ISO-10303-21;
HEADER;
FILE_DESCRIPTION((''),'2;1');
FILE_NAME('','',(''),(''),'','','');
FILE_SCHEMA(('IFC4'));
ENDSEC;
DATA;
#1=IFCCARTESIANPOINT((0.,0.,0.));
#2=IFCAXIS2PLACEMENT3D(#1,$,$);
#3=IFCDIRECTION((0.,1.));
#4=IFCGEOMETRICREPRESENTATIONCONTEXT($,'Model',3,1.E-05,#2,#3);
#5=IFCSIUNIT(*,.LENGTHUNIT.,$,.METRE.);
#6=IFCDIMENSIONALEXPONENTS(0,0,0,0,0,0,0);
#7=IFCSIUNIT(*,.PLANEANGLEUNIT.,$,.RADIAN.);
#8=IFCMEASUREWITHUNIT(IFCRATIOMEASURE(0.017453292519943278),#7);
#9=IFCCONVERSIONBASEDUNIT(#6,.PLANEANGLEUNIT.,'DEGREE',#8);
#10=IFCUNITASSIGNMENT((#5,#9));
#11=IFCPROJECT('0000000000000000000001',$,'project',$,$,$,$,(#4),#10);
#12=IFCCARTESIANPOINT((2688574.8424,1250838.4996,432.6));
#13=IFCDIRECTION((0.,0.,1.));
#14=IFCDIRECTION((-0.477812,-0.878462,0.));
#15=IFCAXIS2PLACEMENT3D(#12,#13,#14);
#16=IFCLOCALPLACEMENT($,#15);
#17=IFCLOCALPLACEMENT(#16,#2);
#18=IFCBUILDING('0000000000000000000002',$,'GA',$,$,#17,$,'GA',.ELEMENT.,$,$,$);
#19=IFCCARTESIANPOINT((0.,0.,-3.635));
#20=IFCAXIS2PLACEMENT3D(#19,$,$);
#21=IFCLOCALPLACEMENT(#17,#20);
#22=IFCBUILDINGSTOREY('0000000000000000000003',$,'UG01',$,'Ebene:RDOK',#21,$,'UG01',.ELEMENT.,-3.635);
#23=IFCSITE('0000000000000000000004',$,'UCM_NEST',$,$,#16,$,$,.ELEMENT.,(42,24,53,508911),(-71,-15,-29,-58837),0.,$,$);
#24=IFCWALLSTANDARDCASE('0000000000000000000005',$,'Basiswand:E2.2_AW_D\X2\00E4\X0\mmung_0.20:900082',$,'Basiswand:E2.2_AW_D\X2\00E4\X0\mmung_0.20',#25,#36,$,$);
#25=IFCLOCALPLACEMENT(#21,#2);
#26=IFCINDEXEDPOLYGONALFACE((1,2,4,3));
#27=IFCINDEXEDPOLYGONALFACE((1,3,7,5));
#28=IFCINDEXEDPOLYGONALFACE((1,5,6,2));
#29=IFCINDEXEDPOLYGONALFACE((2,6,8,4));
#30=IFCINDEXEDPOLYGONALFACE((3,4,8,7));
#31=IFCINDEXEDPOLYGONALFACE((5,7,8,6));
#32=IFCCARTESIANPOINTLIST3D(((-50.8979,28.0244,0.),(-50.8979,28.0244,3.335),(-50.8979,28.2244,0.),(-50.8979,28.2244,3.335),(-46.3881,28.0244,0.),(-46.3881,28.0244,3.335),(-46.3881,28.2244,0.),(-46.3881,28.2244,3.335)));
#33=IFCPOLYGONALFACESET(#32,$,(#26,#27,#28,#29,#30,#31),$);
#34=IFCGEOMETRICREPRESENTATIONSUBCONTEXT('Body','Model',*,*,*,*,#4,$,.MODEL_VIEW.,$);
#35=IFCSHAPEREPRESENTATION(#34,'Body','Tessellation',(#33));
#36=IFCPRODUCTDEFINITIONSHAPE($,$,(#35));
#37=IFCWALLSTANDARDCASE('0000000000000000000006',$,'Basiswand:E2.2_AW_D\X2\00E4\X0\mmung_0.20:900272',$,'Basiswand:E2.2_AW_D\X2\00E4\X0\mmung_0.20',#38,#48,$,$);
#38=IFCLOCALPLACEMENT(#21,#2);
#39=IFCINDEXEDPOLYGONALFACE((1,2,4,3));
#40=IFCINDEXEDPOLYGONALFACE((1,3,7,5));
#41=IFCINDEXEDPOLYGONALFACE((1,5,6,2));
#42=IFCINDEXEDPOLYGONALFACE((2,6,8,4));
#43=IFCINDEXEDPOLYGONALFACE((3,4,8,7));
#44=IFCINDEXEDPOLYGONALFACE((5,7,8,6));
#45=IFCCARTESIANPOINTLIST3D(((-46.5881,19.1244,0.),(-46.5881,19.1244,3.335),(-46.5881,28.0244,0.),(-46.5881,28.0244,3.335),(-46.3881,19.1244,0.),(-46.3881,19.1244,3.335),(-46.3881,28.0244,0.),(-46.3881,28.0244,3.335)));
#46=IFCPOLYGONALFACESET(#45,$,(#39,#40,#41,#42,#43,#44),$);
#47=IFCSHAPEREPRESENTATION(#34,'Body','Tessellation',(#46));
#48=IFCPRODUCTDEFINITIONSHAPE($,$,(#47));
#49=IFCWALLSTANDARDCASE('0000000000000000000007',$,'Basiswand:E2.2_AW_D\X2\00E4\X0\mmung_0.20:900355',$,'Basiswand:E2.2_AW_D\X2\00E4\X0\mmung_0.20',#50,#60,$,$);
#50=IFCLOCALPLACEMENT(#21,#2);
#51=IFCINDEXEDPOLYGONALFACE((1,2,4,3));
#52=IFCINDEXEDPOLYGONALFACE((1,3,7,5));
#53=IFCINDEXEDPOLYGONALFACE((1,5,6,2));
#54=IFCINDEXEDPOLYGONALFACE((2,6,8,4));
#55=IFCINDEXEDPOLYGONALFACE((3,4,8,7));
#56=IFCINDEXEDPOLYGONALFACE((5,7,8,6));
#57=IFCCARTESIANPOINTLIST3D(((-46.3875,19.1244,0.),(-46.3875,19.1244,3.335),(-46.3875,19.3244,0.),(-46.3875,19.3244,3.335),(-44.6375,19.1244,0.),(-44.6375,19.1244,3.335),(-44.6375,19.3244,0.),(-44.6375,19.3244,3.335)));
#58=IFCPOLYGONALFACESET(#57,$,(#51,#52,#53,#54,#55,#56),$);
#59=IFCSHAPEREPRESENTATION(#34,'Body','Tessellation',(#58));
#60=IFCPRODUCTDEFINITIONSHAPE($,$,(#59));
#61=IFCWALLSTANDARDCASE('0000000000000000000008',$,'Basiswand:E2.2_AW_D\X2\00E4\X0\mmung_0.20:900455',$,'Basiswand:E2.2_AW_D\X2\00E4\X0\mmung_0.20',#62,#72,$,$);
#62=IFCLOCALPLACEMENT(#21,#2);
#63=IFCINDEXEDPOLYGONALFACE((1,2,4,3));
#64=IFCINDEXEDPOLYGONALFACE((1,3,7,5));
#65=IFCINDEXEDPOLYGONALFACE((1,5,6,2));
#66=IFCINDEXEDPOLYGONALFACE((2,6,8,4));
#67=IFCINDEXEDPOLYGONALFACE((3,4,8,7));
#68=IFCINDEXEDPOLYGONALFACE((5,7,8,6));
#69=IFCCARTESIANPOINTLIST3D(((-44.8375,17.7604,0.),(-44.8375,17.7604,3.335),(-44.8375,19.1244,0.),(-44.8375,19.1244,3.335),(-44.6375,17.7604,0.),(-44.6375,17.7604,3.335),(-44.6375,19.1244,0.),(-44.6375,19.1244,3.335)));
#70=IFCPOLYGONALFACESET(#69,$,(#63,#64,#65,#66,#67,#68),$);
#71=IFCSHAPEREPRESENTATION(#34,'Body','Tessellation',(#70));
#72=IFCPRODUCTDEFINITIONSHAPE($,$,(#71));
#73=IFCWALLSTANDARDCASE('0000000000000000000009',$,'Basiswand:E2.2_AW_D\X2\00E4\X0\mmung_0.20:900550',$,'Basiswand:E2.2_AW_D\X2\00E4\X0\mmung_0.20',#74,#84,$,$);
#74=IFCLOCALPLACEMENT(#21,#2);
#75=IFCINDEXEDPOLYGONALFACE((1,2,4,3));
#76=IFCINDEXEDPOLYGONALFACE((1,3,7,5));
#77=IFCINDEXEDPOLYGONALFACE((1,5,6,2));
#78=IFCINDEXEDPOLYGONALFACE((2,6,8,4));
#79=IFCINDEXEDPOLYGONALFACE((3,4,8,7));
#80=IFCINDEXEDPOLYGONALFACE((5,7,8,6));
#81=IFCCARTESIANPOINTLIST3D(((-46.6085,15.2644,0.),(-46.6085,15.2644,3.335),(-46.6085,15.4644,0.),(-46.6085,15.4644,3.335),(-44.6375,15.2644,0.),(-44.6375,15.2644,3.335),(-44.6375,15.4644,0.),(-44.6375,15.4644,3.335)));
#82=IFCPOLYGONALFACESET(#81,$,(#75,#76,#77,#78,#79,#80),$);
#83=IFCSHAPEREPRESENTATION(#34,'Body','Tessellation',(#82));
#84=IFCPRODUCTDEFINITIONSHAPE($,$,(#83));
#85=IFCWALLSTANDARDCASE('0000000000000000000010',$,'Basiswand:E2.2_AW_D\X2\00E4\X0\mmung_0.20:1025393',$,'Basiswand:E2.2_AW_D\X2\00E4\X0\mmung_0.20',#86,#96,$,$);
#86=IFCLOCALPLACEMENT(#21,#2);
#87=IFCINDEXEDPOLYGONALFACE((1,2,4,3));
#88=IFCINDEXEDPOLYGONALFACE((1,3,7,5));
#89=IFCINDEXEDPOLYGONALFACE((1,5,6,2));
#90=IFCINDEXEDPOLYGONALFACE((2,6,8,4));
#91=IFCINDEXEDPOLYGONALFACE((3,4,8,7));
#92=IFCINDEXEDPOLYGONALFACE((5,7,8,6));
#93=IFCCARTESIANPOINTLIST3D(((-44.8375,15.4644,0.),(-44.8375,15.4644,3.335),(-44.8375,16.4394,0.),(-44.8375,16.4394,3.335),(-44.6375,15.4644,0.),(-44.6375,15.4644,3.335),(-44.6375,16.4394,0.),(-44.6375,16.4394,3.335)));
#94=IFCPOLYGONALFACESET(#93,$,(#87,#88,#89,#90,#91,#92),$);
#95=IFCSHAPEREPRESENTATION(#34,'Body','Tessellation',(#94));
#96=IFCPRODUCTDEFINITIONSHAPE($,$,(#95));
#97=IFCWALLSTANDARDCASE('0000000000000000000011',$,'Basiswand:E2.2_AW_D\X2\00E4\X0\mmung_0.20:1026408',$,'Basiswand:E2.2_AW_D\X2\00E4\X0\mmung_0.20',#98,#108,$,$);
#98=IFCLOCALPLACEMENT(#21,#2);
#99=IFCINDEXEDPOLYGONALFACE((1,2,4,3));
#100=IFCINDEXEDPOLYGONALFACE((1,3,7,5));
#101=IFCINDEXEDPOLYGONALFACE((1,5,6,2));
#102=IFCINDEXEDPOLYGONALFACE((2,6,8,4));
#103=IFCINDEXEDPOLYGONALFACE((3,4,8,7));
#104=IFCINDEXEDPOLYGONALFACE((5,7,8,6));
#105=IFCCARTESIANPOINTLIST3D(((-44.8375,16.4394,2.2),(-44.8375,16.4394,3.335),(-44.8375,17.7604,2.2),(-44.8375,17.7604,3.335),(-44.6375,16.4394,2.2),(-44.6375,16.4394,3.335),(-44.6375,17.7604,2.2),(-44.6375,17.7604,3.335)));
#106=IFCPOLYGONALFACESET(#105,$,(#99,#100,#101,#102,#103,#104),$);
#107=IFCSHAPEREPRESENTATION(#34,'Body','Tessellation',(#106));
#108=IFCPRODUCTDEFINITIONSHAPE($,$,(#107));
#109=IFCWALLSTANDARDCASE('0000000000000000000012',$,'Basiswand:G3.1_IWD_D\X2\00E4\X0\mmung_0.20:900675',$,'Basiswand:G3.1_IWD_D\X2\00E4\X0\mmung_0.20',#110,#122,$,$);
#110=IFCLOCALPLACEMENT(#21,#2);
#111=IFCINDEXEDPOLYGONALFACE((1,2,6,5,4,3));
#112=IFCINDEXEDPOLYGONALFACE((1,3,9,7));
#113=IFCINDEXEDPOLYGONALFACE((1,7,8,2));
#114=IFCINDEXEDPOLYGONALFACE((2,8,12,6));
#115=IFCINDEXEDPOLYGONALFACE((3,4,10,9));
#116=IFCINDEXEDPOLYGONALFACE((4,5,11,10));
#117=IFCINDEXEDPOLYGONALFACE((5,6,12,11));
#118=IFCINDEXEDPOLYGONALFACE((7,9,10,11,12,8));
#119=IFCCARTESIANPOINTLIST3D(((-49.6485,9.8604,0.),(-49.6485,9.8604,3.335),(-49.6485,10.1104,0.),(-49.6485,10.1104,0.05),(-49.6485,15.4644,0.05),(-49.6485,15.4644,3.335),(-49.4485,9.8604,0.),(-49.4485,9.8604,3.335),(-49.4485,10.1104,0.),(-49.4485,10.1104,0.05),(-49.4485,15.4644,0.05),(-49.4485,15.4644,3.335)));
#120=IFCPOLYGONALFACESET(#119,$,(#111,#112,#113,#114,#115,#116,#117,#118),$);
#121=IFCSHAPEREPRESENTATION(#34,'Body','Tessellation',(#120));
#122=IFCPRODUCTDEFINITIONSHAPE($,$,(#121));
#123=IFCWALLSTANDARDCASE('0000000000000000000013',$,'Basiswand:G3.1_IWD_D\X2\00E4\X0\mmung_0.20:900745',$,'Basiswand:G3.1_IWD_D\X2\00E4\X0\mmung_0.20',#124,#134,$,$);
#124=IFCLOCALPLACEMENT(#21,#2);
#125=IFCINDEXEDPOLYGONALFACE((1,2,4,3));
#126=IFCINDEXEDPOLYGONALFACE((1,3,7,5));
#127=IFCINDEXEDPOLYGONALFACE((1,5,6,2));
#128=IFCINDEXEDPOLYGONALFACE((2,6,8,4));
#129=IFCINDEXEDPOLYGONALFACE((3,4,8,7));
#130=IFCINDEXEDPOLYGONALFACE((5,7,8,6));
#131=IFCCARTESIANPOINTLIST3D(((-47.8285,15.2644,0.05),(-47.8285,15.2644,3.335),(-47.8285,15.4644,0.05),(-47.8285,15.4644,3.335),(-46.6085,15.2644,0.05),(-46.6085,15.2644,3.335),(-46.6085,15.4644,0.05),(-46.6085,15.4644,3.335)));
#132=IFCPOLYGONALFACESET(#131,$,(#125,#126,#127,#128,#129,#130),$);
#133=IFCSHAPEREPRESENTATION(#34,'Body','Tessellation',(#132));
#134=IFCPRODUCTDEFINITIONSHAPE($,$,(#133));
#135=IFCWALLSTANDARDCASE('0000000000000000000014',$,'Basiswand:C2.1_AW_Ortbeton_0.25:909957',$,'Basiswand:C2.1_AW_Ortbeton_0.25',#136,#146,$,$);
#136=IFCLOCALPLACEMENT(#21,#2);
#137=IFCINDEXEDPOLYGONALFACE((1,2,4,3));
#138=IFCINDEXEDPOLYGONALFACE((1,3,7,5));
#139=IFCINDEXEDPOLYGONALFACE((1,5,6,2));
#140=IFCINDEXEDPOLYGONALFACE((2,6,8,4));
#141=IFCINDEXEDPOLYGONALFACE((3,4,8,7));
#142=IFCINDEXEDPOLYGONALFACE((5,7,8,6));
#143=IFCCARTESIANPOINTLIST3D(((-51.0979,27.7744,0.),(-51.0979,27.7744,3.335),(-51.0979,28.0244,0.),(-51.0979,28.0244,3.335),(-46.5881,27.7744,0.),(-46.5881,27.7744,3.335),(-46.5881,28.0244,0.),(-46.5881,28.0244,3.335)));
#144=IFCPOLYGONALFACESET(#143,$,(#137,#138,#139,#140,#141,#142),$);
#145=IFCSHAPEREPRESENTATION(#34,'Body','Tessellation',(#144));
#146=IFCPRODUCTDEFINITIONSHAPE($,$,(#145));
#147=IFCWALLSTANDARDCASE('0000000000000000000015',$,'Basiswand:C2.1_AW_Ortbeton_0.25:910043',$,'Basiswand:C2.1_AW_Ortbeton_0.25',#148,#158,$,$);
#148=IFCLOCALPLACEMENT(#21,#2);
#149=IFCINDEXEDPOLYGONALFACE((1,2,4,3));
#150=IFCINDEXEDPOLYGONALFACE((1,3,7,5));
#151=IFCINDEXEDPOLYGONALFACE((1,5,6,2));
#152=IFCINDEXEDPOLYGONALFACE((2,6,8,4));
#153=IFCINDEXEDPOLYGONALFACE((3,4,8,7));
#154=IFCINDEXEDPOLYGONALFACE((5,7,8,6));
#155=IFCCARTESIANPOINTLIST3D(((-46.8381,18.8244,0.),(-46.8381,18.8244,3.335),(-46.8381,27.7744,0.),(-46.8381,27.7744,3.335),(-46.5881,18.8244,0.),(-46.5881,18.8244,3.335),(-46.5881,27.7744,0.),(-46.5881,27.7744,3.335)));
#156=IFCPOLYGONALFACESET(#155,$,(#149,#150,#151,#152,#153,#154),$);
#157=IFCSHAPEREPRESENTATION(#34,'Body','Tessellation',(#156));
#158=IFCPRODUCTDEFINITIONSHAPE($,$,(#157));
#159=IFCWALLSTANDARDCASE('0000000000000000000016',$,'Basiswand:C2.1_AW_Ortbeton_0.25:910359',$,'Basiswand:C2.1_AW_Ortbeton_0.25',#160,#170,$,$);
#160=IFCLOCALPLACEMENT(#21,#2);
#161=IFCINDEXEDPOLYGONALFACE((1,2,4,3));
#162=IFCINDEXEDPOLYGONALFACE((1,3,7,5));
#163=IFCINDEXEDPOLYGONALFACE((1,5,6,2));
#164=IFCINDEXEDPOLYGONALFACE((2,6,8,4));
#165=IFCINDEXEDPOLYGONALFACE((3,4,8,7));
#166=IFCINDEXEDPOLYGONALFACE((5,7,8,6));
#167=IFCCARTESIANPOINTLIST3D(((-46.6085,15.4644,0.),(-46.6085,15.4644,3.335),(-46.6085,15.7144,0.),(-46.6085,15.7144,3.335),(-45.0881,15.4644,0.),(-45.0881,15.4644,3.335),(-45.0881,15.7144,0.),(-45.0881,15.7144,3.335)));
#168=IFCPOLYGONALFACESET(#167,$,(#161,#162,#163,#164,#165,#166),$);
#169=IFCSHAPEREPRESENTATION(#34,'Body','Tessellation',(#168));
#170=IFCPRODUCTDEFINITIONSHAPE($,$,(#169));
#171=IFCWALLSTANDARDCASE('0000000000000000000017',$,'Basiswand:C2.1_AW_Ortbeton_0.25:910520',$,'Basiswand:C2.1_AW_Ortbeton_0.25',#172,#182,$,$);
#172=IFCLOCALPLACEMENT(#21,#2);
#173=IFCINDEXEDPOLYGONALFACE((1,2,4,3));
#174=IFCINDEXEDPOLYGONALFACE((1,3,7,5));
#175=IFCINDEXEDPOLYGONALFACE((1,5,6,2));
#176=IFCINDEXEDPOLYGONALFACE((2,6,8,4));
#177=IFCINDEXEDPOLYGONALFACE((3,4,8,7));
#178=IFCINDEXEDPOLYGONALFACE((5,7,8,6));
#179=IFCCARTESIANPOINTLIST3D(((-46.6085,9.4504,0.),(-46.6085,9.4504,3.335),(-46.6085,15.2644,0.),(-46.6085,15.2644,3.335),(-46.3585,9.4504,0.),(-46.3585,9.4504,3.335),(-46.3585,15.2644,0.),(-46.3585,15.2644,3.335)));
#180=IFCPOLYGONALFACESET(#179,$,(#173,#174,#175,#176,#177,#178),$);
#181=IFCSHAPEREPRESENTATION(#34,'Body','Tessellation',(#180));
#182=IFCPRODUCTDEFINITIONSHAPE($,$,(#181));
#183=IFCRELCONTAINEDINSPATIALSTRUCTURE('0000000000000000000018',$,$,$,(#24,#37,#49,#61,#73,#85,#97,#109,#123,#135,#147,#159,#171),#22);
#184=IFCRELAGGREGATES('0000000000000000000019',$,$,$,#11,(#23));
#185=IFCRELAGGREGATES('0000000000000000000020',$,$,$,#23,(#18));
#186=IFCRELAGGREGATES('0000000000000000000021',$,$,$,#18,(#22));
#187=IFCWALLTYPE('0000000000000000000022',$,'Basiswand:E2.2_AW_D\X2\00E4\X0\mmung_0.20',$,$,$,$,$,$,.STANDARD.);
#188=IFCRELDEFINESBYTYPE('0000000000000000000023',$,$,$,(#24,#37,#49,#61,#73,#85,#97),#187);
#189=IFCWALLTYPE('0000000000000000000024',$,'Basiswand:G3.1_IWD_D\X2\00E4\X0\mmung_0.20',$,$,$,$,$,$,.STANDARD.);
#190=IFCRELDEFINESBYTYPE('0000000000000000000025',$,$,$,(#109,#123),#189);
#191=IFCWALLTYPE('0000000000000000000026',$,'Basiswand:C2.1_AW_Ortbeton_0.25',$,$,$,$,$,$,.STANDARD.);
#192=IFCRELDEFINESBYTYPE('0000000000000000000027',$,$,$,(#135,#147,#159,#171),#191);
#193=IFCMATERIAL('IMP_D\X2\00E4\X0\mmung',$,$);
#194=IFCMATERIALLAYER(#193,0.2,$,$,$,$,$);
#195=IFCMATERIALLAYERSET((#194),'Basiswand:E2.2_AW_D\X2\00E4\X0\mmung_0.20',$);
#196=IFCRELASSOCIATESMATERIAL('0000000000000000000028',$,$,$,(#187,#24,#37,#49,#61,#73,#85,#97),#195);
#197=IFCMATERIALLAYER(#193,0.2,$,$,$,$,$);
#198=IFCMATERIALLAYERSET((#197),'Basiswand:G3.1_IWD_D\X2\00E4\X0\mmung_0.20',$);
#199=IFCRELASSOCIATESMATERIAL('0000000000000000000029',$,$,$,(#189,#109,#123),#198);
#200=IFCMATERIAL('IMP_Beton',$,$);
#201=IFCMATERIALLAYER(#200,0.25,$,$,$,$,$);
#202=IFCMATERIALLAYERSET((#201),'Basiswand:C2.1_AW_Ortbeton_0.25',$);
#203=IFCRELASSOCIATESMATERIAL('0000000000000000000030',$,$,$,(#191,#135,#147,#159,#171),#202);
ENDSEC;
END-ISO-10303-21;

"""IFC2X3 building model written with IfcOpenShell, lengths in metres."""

from ifc_helpers import new_model, entity, si_unit, converted_unit, direction, frame, frame_2d, origin, place, context, subcontext, project, spatial, polyline, rectangle, extrude, clip, bounded_halfspace, material, layer, layer_set, layer_usage, type_object, element, save


model = new_model("IFC2X3")

# Units and contexts
model_context = context("Model", 3, precision=1e-05, world=origin(), true_north=direction((0.0, 1.0)))
body_context = subcontext(model_context, "Body", "Model", "MODEL_VIEW")
ifc_project = project(units=[si_unit("LENGTHUNIT", "METRE"), converted_unit("PLANEANGLEUNIT", "DEGREE", entity("IfcRatioMeasure", 0.017453292519943278), si_unit("PLANEANGLEUNIT", "RADIAN"), dimensions=[0, 0, 0, 0, 0, 0, 0])], contexts=[model_context])

# Site, building, storey
site_placement = place(None, frame((2688574.8424, 1250838.4996, 432.6), z_axis=(0.0, 0.0, 1.0), x_axis=(-0.477812, -0.878462, 0.0)))
site = spatial("IfcSite", under=ifc_project, at=site_placement, Name="UCM_NEST", CompositionType="ELEMENT", RefLatitude=(42, 24, 53, 508911), RefLongitude=(-71, -15, -29, -58837), RefElevation=0.0)
building_placement = place(site_placement, origin())
building = spatial("IfcBuilding", under=site, at=building_placement, Name="GA", LongName="GA", CompositionType="ELEMENT")
storey_placement = place(building_placement, frame((0.0, 0.0, -3.635)))
storey = spatial("IfcBuildingStorey", under=building, at=storey_placement, Name="UG01", ObjectType="Ebene:RDOK", LongName="UG01", CompositionType="ELEMENT", Elevation=-3.635)

# Shared definitions
ifc_material_1 = material(Name="IMP_Beton")

# Walls
ifc_material_2 = material(Name="IMP_Dämmung")
ifc_layer_1 = layer(ifc_material_2, 0.2)
ifc_layer_set_1 = layer_set([ifc_layer_1], Name="Basiswand:E2.2_AW_Dämmung_0.20")
ifc_layer_usage_1 = layer_usage(ifc_layer_set_1, "AXIS2", "NEGATIVE", 0.1)
wall_type_1 = type_object("IfcWallType", Name="Basiswand:E2.2_AW_Dämmung_0.20", PredefinedType="STANDARD", material=ifc_layer_set_1)
wall_1_placement = place(storey_placement, frame((-50.8979, 28.1244, 0.0)))
element("IfcWallStandardCase", 1, at=wall_1_placement, inside=storey, type_object=wall_type_1, material=ifc_layer_usage_1, Name="Basiswand:E2.2_AW_Dämmung_0.20:900082", ObjectType="Basiswand:E2.2_AW_Dämmung_0.20", context=body_context, shape_type="SweptSolid", body=[
    extrude(rectangle(XDim=4.5099, YDim=0.2, at=frame_2d((2.2549, 0.0), x_axis=(-1.0, 0.0))), origin(), (0.0, 0.0, 1.0), 3.335),
])
wall_2_placement = place(storey_placement, frame((-46.4881, 28.0244, 0.0), z_axis=(0.0, 0.0, 1.0), x_axis=(0.0, -1.0, 0.0)))
element("IfcWallStandardCase", 2, at=wall_2_placement, inside=storey, type_object=wall_type_1, material=ifc_layer_usage_1, Name="Basiswand:E2.2_AW_Dämmung_0.20:900272", ObjectType="Basiswand:E2.2_AW_Dämmung_0.20", context=body_context, shape_type="SweptSolid", body=[
    extrude(rectangle(XDim=8.9, YDim=0.2, at=frame_2d((4.45, 0.0), x_axis=(-1.0, 0.0))), origin(), (0.0, 0.0, 1.0), 3.335),
])
wall_3_placement = place(storey_placement, frame((-46.3875, 19.2244, 0.0)))
element("IfcWallStandardCase", 3, at=wall_3_placement, inside=storey, type_object=wall_type_1, material=ifc_layer_usage_1, Name="Basiswand:E2.2_AW_Dämmung_0.20:900355", ObjectType="Basiswand:E2.2_AW_Dämmung_0.20", context=body_context, shape_type="SweptSolid", body=[
    extrude(rectangle(XDim=1.75, YDim=0.2, at=frame_2d((0.875, 0.0), x_axis=(-1.0, 0.0))), origin(), (0.0, 0.0, 1.0), 3.335),
])
wall_4_placement = place(storey_placement, frame((-44.7375, 19.1244, 0.0), z_axis=(0.0, 0.0, 1.0), x_axis=(0.0, -1.0, 0.0)))
element("IfcWallStandardCase", 4, at=wall_4_placement, inside=storey, type_object=wall_type_1, material=ifc_layer_usage_1, Name="Basiswand:E2.2_AW_Dämmung_0.20:900455", ObjectType="Basiswand:E2.2_AW_Dämmung_0.20", context=body_context, shape_type="SweptSolid", body=[
    extrude(rectangle(XDim=1.364, YDim=0.2, at=frame_2d((0.682, 0.0), x_axis=(-1.0, 0.0))), origin(), (0.0, 0.0, 1.0), 3.335),
])
wall_5_placement = place(storey_placement, frame((-44.6375, 15.3644, 0.0), z_axis=(0.0, 0.0, 1.0), x_axis=(-1.0, 0.0, 0.0)))
element("IfcWallStandardCase", 5, at=wall_5_placement, inside=storey, type_object=wall_type_1, material=ifc_layer_usage_1, Name="Basiswand:E2.2_AW_Dämmung_0.20:900550", ObjectType="Basiswand:E2.2_AW_Dämmung_0.20", context=body_context, shape_type="SweptSolid", body=[
    extrude(rectangle(XDim=1.971, YDim=0.2, at=frame_2d((0.9855, 0.0), x_axis=(-1.0, 0.0))), origin(), (0.0, 0.0, 1.0), 3.335),
])
wall_6_placement = place(storey_placement, frame((-44.7375, 16.4394, 0.0), z_axis=(0.0, 0.0, 1.0), x_axis=(0.0, -1.0, 0.0)))
element("IfcWallStandardCase", 6, at=wall_6_placement, inside=storey, type_object=wall_type_1, material=ifc_layer_usage_1, Name="Basiswand:E2.2_AW_Dämmung_0.20:1025393", ObjectType="Basiswand:E2.2_AW_Dämmung_0.20", context=body_context, shape_type="SweptSolid", body=[
    extrude(rectangle(XDim=0.975, YDim=0.2, at=frame_2d((0.4875, 0.0), x_axis=(-1.0, 0.0))), origin(), (0.0, 0.0, 1.0), 3.335),
])
wall_7_placement = place(storey_placement, frame((-44.7375, 17.7604, 2.2), z_axis=(0.0, 0.0, 1.0), x_axis=(0.0, -1.0, 0.0)))
element("IfcWallStandardCase", 7, at=wall_7_placement, inside=storey, type_object=wall_type_1, material=ifc_layer_usage_1, Name="Basiswand:E2.2_AW_Dämmung_0.20:1026408", ObjectType="Basiswand:E2.2_AW_Dämmung_0.20", context=body_context, shape_type="SweptSolid", body=[
    extrude(rectangle(XDim=1.321, YDim=0.2, at=frame_2d((0.6605, 0.0), x_axis=(-1.0, 0.0))), origin(), (0.0, 0.0, 1.0), 1.135),
])
ifc_layer_2 = layer(ifc_material_2, 0.2)
ifc_layer_set_2 = layer_set([ifc_layer_2], Name="Basiswand:G3.1_IWD_Dämmung_0.20")
ifc_layer_usage_2 = layer_usage(ifc_layer_set_2, "AXIS2", "NEGATIVE", 0.1)
wall_type_2 = type_object("IfcWallType", Name="Basiswand:G3.1_IWD_Dämmung_0.20", PredefinedType="STANDARD", material=ifc_layer_set_2)
wall_8_placement = place(storey_placement, frame((-49.5485, 15.4644, 0.0), z_axis=(0.0, 0.0, 1.0), x_axis=(0.0, -1.0, 0.0)))
element("IfcWallStandardCase", 8, at=wall_8_placement, inside=storey, type_object=wall_type_2, material=ifc_layer_usage_2, Name="Basiswand:G3.1_IWD_Dämmung_0.20:900675", ObjectType="Basiswand:G3.1_IWD_Dämmung_0.20", context=body_context, shape_type="Clipping", body=[
    clip(clip(extrude(rectangle(XDim=5.604, YDim=0.2, at=frame_2d((2.802, 0.0), x_axis=(-1.0, 0.0))), origin(), (0.0, 0.0, 1.0), 3.335), bounded_halfspace(frame((5.354, 0.1, 0.05), z_axis=(0.0, 0.0, 1.0), x_axis=(-1.0, 0.0, 0.0)), True, frame((5.354, 0.1, 0.05), z_axis=(0.0, 0.0, 1.0), x_axis=(-1.0, 0.0, 0.0)), polyline([(0.0, 0.0), (5.354, 0.0), (5.354, 0.2), (0.0, 0.2), (0.0, 0.0)]))), bounded_halfspace(frame((5.354, -0.1, 0.05), z_axis=(1.0, 0.0, 0.0), x_axis=(0.0, 0.0, 1.0)), True, frame((5.354, -0.1, 0.05), z_axis=(1.0, 0.0, 0.0), x_axis=(0.0, 0.0, 1.0)), polyline([(0.0, 0.0), (-0.05, 0.0), (-0.05, -0.2), (0.0, -0.2), (0.0, 0.0)]))),
])
wall_9_placement = place(storey_placement, frame((-47.8285, 15.3644, 0.05)))
element("IfcWallStandardCase", 9, at=wall_9_placement, inside=storey, type_object=wall_type_2, material=ifc_layer_usage_2, Name="Basiswand:G3.1_IWD_Dämmung_0.20:900745", ObjectType="Basiswand:G3.1_IWD_Dämmung_0.20", context=body_context, shape_type="Clipping", body=[
    clip(extrude(rectangle(XDim=1.22, YDim=0.2, at=frame_2d((0.61, 0.0), x_axis=(-1.0, 0.0))), origin(), (0.0, 0.0, 1.0), 3.285), bounded_halfspace(frame((1.22, -0.1, 0.0), z_axis=(0.0, 0.0, 1.0), x_axis=(0.0, 1.0, 0.0)), True, frame((1.22, -0.1, 0.0), z_axis=(0.0, 0.0, 1.0), x_axis=(0.0, 1.0, 0.0)), polyline([(0.0, 0.0), (0.2, 0.0), (0.2, 1.22), (0.0, 1.22), (0.0, 0.0)]))),
])
ifc_layer_3 = layer(ifc_material_1, 0.25)
ifc_layer_set_3 = layer_set([ifc_layer_3], Name="Basiswand:C2.1_AW_Ortbeton_0.25")
ifc_layer_usage_3 = layer_usage(ifc_layer_set_3, "AXIS2", "NEGATIVE", 0.125)
wall_type_3 = type_object("IfcWallType", Name="Basiswand:C2.1_AW_Ortbeton_0.25", PredefinedType="STANDARD", material=ifc_layer_set_3)
wall_10_placement = place(storey_placement, frame((-51.0979, 27.8994, 0.0)))
element("IfcWallStandardCase", 10, at=wall_10_placement, inside=storey, type_object=wall_type_3, material=ifc_layer_usage_3, Name="Basiswand:C2.1_AW_Ortbeton_0.25:909957", ObjectType="Basiswand:C2.1_AW_Ortbeton_0.25", context=body_context, shape_type="SweptSolid", body=[
    extrude(rectangle(XDim=4.5099, YDim=0.25, at=frame_2d((2.2549, 0.0), x_axis=(-1.0, 0.0))), origin(), (0.0, 0.0, 1.0), 3.335),
])
wall_11_placement = place(storey_placement, frame((-46.7131, 27.7744, 0.0), z_axis=(0.0, 0.0, 1.0), x_axis=(0.0, -1.0, 0.0)))
element("IfcWallStandardCase", 11, at=wall_11_placement, inside=storey, type_object=wall_type_3, material=ifc_layer_usage_3, Name="Basiswand:C2.1_AW_Ortbeton_0.25:910043", ObjectType="Basiswand:C2.1_AW_Ortbeton_0.25", context=body_context, shape_type="SweptSolid", body=[
    extrude(rectangle(XDim=8.95, YDim=0.25, at=frame_2d((4.475, 0.0), x_axis=(-1.0, 0.0))), origin(), (0.0, 0.0, 1.0), 3.335),
])

# Walls
wall_12_placement = place(storey_placement, frame((-45.0881, 15.5894, 0.0), z_axis=(0.0, 0.0, 1.0), x_axis=(-1.0, 0.0, 0.0)))
element("IfcWallStandardCase", 12, at=wall_12_placement, inside=storey, type_object=wall_type_3, material=ifc_layer_usage_3, Name="Basiswand:C2.1_AW_Ortbeton_0.25:910359", ObjectType="Basiswand:C2.1_AW_Ortbeton_0.25", context=body_context, shape_type="SweptSolid", body=[
    extrude(rectangle(XDim=1.5204, YDim=0.25, at=frame_2d((0.7602, 0.0), x_axis=(-1.0, 0.0))), origin(), (0.0, 0.0, 1.0), 3.335),
])
wall_13_placement = place(storey_placement, frame((-46.4835, 15.2644, 0.0), z_axis=(0.0, 0.0, 1.0), x_axis=(0.0, -1.0, 0.0)))
element("IfcWallStandardCase", 13, at=wall_13_placement, inside=storey, type_object=wall_type_3, material=ifc_layer_usage_3, Name="Basiswand:C2.1_AW_Ortbeton_0.25:910520", ObjectType="Basiswand:C2.1_AW_Ortbeton_0.25", context=body_context, shape_type="SweptSolid", body=[
    extrude(rectangle(XDim=5.814, YDim=0.25, at=frame_2d((2.907, 0.0), x_axis=(-1.0, 0.0))), origin(), (0.0, 0.0, 1.0), 3.335),
])

save(model, "model.ifc")
